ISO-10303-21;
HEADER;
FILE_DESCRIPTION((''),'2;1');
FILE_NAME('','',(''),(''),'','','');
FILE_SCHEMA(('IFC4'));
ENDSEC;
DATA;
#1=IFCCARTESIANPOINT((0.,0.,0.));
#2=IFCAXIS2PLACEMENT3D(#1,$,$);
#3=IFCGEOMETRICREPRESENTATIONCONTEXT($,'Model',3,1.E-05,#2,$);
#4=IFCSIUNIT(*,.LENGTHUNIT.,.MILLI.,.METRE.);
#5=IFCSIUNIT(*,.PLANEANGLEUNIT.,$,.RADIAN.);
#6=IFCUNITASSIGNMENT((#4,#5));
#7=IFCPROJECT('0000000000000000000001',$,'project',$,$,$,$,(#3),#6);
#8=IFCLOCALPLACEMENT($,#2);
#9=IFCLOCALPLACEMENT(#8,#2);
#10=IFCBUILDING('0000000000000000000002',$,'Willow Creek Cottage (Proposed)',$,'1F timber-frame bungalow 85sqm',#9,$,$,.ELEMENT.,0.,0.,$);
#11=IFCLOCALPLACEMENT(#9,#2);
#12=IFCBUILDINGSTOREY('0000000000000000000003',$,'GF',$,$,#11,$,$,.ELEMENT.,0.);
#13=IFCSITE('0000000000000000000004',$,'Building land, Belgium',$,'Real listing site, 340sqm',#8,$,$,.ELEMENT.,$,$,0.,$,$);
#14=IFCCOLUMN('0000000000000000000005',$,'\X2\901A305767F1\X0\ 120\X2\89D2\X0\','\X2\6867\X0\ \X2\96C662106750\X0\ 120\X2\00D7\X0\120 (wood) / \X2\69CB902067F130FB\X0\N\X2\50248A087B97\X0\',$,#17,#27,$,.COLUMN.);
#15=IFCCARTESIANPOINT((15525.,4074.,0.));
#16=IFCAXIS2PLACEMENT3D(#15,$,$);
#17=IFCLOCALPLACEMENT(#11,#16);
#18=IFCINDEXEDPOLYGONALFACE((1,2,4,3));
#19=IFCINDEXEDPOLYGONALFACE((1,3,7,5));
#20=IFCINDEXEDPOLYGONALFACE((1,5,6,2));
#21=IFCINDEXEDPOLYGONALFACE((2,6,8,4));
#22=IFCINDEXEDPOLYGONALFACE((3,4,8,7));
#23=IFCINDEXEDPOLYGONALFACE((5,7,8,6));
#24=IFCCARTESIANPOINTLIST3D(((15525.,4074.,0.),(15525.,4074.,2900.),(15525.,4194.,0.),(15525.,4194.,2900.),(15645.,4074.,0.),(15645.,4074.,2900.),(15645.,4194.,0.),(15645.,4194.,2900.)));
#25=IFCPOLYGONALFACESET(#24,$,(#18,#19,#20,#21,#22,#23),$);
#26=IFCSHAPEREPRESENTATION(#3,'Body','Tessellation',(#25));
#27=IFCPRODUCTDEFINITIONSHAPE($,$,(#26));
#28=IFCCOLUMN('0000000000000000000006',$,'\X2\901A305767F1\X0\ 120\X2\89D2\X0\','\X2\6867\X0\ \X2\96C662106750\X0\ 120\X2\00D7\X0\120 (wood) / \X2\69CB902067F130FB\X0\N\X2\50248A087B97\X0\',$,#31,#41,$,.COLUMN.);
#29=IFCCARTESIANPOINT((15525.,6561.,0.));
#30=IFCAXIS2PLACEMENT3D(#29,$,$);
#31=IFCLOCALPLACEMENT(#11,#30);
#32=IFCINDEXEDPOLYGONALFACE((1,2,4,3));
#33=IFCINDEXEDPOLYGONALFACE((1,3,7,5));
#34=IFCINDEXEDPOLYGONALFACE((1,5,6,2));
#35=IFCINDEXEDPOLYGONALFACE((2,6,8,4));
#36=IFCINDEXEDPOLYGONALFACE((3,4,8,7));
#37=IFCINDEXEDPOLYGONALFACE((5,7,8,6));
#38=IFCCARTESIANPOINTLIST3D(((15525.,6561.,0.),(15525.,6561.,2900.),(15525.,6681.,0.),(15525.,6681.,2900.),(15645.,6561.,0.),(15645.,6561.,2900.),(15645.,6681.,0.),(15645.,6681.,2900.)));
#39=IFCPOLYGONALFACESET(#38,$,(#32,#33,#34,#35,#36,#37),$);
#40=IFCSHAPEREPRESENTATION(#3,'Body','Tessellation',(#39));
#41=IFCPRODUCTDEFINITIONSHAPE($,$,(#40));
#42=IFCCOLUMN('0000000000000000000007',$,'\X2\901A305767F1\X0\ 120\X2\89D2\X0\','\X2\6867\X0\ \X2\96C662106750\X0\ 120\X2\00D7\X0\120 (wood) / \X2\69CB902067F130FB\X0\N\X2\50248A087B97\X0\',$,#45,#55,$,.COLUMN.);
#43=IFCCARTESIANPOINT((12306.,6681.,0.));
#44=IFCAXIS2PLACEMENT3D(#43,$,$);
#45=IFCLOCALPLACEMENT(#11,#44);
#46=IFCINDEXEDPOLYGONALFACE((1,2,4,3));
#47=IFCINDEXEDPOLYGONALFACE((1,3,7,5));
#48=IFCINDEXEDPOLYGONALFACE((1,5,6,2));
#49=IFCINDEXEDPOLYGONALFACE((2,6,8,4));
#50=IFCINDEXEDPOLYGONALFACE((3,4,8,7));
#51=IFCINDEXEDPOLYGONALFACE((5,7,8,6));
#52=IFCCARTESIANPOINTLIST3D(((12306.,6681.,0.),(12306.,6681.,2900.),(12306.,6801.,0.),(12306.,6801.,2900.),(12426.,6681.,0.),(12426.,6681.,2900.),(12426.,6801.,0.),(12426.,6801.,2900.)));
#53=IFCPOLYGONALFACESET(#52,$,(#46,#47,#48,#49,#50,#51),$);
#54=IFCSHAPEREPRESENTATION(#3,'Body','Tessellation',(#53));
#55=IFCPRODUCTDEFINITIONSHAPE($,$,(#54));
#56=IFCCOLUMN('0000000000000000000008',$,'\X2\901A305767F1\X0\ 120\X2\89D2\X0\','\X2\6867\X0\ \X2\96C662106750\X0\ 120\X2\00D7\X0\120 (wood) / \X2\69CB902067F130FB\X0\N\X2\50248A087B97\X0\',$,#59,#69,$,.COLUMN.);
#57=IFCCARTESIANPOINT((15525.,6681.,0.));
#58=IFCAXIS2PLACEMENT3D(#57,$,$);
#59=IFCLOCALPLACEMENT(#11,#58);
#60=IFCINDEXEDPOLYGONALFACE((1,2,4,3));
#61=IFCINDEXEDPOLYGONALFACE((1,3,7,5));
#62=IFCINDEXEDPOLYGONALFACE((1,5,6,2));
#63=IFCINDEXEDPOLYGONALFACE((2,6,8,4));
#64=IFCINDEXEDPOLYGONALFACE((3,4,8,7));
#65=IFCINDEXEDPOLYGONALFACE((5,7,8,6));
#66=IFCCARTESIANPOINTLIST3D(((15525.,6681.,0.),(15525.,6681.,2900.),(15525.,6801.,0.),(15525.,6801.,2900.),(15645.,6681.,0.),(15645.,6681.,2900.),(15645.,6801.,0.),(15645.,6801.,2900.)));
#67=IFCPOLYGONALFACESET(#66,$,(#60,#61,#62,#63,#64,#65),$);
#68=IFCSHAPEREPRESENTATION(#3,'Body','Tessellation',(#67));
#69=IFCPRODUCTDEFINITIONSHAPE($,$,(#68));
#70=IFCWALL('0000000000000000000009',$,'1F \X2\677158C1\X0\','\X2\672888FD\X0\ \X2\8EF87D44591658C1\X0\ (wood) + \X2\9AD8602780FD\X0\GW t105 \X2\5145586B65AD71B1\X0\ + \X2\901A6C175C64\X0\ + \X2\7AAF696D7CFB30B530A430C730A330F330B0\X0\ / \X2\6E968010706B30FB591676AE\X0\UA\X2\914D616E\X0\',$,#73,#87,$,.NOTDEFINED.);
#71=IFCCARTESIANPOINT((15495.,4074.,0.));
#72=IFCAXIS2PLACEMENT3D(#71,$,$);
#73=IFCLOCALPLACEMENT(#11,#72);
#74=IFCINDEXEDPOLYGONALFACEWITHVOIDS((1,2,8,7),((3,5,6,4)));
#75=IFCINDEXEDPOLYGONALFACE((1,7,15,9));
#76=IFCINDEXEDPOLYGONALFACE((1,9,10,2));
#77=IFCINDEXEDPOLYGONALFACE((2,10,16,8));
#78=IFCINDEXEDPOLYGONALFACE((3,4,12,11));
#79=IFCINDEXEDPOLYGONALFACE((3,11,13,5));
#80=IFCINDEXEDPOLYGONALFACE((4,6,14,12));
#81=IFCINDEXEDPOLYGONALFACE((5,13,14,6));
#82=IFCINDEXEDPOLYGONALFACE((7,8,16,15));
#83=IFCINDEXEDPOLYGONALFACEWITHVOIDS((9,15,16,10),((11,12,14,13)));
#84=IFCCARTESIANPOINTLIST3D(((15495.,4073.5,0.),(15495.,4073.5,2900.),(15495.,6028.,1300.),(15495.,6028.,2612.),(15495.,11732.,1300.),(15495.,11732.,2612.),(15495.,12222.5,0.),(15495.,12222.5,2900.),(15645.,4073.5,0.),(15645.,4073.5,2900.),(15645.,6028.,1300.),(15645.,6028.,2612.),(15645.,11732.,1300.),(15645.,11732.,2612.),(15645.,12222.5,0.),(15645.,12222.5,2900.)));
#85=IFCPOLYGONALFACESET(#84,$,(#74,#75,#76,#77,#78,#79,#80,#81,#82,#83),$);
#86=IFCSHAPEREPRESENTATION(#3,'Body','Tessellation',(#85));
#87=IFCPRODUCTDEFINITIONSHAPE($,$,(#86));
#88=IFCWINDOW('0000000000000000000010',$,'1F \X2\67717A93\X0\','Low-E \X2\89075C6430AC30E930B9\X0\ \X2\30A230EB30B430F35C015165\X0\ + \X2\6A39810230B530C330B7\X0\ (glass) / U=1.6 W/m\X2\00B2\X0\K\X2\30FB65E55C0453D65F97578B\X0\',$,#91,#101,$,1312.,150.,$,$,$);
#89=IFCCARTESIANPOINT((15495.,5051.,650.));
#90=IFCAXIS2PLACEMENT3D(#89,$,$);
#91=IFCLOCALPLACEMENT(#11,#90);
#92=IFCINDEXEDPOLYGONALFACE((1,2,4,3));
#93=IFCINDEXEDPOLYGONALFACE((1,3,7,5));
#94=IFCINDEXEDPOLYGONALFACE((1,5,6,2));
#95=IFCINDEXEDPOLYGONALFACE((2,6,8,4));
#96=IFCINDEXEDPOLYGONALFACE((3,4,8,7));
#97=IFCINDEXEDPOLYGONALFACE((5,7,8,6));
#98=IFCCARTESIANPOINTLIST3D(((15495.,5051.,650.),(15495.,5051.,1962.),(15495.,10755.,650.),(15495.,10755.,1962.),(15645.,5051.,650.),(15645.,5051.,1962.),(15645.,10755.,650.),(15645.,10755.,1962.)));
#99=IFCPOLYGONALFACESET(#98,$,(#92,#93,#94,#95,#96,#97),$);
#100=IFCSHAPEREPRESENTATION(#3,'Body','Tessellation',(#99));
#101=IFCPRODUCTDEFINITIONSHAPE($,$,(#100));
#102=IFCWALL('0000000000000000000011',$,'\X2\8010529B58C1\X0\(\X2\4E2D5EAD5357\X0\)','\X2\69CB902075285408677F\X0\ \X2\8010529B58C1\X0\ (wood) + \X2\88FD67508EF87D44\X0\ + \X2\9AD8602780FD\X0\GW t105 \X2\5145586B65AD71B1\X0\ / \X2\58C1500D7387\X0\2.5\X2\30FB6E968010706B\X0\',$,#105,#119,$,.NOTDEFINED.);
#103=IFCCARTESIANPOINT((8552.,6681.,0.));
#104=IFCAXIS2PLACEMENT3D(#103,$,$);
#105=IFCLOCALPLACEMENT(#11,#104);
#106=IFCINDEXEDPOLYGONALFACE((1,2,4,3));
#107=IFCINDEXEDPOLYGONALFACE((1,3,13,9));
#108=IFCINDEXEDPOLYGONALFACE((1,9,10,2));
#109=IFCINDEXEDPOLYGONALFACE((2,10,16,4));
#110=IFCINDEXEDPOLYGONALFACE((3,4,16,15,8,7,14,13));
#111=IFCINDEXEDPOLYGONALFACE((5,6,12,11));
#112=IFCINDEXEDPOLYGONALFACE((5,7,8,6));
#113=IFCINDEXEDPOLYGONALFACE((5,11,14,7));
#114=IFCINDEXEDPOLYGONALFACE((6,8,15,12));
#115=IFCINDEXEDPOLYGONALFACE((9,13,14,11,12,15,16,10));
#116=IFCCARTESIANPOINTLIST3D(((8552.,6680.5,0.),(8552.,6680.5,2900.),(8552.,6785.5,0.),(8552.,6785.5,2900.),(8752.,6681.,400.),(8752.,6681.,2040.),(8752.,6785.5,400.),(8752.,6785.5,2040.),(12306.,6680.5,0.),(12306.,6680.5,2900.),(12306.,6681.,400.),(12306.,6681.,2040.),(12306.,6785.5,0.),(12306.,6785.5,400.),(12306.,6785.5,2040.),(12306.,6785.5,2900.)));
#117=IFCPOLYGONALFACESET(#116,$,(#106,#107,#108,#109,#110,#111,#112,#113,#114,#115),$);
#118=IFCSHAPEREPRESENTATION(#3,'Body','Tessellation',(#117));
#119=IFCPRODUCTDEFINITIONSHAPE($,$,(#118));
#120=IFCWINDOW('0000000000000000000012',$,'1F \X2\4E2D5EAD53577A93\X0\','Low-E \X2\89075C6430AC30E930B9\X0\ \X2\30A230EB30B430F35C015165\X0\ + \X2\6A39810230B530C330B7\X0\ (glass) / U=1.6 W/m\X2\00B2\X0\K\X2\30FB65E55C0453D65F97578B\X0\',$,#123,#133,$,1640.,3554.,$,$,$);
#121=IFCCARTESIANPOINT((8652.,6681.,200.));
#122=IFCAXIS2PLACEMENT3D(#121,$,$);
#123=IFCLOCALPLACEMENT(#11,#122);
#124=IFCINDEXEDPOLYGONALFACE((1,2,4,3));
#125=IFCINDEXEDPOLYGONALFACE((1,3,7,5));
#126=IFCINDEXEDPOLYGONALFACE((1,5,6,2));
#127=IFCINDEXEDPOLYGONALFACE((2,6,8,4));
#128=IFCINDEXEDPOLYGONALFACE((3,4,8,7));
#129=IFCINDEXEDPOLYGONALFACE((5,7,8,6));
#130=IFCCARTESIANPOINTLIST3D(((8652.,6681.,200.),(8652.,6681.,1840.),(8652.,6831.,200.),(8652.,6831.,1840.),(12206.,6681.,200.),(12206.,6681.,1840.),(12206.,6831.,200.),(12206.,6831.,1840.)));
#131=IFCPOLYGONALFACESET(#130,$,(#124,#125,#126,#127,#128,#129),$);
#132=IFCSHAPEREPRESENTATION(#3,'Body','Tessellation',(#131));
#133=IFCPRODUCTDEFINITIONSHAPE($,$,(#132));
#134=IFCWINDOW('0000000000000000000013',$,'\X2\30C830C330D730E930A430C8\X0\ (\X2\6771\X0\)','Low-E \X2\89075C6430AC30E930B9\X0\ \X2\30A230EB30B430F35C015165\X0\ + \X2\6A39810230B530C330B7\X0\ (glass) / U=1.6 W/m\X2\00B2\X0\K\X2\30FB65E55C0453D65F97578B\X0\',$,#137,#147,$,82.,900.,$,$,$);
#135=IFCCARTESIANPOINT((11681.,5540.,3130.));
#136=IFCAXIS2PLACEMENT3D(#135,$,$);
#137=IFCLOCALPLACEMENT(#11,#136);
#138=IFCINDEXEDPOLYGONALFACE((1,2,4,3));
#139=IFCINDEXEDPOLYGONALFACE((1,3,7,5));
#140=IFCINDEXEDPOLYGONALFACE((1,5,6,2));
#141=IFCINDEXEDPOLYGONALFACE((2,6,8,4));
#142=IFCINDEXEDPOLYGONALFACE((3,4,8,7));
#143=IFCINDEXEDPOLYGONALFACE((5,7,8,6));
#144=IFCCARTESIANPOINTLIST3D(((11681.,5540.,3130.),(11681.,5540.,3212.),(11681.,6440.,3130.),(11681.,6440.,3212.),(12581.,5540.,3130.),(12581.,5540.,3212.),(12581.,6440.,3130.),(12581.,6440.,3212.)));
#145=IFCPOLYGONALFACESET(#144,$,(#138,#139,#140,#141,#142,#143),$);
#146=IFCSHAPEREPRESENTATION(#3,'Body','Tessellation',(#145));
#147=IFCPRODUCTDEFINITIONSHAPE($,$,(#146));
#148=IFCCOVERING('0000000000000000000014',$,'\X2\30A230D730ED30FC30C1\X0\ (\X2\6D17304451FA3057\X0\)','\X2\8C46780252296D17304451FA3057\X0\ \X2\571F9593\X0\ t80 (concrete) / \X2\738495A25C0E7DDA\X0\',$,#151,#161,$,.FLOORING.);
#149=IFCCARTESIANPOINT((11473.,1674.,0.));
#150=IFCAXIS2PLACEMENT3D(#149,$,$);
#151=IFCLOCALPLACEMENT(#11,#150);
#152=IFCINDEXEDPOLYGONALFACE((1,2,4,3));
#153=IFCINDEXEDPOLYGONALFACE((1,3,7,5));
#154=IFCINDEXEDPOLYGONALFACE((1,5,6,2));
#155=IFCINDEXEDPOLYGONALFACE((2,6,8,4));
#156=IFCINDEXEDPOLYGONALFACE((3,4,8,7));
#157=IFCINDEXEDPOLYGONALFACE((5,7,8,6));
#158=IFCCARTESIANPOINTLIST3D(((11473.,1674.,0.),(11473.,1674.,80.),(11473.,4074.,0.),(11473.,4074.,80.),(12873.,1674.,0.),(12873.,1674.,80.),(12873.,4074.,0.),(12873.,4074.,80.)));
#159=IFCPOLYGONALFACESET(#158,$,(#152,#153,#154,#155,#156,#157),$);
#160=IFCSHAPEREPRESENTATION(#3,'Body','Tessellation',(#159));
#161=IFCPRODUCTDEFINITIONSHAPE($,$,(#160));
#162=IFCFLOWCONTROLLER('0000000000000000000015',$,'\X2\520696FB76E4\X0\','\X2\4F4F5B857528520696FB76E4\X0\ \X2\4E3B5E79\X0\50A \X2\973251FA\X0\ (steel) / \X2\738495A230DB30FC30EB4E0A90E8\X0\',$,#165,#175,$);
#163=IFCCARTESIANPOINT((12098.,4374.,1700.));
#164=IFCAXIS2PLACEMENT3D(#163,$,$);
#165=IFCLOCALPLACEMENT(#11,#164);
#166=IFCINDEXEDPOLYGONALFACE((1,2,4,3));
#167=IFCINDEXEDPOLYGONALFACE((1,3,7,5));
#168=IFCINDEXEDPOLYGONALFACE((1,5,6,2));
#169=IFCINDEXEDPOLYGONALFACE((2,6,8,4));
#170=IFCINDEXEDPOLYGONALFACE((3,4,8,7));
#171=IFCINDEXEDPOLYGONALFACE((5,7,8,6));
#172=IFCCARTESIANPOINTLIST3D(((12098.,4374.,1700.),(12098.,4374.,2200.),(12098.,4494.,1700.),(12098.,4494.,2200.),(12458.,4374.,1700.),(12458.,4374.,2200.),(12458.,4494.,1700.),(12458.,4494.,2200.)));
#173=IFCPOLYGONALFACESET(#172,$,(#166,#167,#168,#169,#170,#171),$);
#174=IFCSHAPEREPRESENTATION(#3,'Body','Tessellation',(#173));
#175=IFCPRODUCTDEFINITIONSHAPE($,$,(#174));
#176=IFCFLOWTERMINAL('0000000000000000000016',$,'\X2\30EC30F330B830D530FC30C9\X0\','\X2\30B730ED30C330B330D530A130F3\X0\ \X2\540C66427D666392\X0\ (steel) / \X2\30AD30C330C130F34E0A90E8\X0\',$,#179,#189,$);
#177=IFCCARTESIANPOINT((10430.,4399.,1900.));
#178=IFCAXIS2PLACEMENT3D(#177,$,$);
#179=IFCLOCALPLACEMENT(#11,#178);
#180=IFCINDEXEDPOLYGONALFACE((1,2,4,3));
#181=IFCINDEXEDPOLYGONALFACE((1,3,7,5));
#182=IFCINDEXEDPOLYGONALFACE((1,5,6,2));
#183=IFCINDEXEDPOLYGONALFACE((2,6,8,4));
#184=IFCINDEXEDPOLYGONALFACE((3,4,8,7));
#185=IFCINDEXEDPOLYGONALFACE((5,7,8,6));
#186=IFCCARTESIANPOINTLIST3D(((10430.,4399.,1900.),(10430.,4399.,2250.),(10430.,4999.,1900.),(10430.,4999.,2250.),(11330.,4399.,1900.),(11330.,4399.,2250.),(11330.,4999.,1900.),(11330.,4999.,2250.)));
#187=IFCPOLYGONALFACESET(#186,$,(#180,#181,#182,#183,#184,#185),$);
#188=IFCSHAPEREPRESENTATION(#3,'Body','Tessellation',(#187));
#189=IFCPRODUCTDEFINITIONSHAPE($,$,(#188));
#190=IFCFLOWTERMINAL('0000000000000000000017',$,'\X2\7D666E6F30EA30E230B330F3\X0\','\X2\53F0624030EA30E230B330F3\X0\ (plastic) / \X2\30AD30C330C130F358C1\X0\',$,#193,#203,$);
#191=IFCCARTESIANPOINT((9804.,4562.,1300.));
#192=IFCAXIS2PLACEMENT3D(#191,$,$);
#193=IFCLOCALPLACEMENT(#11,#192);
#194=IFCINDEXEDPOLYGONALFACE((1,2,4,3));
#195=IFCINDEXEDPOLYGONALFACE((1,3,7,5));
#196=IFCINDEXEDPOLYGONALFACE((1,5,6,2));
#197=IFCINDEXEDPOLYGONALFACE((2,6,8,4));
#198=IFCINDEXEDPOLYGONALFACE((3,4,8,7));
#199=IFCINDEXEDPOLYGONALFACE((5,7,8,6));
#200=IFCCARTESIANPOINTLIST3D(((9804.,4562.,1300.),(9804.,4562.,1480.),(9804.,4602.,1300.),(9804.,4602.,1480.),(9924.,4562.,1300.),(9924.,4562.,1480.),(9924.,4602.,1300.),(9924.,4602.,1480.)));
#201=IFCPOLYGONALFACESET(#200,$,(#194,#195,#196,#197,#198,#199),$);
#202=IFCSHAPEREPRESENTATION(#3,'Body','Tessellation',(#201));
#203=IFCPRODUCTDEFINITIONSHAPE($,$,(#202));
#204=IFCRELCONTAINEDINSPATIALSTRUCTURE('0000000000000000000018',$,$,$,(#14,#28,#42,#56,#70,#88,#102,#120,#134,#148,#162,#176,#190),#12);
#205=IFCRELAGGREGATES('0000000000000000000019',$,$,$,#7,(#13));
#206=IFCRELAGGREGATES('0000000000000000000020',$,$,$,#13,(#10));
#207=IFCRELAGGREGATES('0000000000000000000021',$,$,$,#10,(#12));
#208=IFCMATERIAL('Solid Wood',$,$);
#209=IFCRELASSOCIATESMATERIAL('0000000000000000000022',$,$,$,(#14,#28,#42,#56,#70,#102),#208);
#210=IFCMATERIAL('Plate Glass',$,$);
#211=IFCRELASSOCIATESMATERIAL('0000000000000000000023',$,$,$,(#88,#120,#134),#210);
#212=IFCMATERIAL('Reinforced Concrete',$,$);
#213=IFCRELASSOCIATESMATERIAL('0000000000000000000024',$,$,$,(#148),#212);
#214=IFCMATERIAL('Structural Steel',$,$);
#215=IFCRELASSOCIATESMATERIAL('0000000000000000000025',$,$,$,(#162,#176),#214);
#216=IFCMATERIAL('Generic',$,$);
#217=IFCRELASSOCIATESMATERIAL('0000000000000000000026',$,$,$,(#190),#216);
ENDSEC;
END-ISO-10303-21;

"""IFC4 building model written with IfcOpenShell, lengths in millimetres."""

from ifc_helpers import new_model, si_unit, frame, frame_2d, origin, place, context, project, spatial, rectangle, extrude, material, element, fill, save


model = new_model("IFC4")

# Units and contexts
model_context = context("Model", 3, precision=1e-05, world=origin())
ifc_project = project(units=[si_unit("LENGTHUNIT", "METRE", prefix="MILLI"), si_unit("PLANEANGLEUNIT", "RADIAN")], contexts=[model_context])

# Site, building, storey
site_placement = place(None, origin())
site = spatial("IfcSite", under=ifc_project, at=site_placement, Name="Building land, Belgium", ObjectType="Real listing site, 340sqm", CompositionType="ELEMENT", RefElevation=0.0)
building_placement = place(site_placement, origin())
building = spatial("IfcBuilding", under=site, at=building_placement, Name="Willow Creek Cottage (Proposed)", ObjectType="1F timber-frame bungalow 85sqm", CompositionType="ELEMENT", ElevationOfRefHeight=0.0, ElevationOfTerrain=0.0)
storey_placement = place(building_placement, origin())
storey = spatial("IfcBuildingStorey", under=building, at=storey_placement, Name="GF", CompositionType="ELEMENT", Elevation=0.0)

# Columns
ifc_material_1 = material(Name="Solid Wood")
column_1_placement = place(storey_placement, frame((15525.0, 4074.0, 0.0)))
element("IfcColumn", 1, at=column_1_placement, inside=storey, material=ifc_material_1, Name="通し柱 120角", Description="桧 集成材 120×120 (wood) / 構造柱・N値計算", PredefinedType="COLUMN", context=model_context, shape_type="SweptSolid", body=[
    extrude(rectangle(XDim=120.0, YDim=120.0, at=frame_2d((60.0, 60.0))), frame((15525.0, 4074.0, 0.0)), (0.0, 0.0, 1.0), 2900.0),
])
column_2_placement = place(storey_placement, frame((15525.0, 6561.0, 0.0)))
element("IfcColumn", 2, at=column_2_placement, inside=storey, material=ifc_material_1, Name="通し柱 120角", Description="桧 集成材 120×120 (wood) / 構造柱・N値計算", PredefinedType="COLUMN", context=model_context, shape_type="SweptSolid", body=[
    extrude(rectangle(XDim=120.0, YDim=120.0, at=frame_2d((60.0, 60.0))), frame((15525.0, 6561.0, 0.0)), (0.0, 0.0, 1.0), 2900.0),
])
column_3_placement = place(storey_placement, frame((12306.0, 6681.0, 0.0)))
element("IfcColumn", 3, at=column_3_placement, inside=storey, material=ifc_material_1, Name="通し柱 120角", Description="桧 集成材 120×120 (wood) / 構造柱・N値計算", PredefinedType="COLUMN", context=model_context, shape_type="SweptSolid", body=[
    extrude(rectangle(XDim=120.0, YDim=120.0, at=frame_2d((60.0, 60.0))), frame((12306.0, 6681.0, 0.0)), (0.0, 0.0, 1.0), 2900.0),
])
column_4_placement = place(storey_placement, frame((15525.0, 6681.0, 0.0)))
element("IfcColumn", 4, at=column_4_placement, inside=storey, material=ifc_material_1, Name="通し柱 120角", Description="桧 集成材 120×120 (wood) / 構造柱・N値計算", PredefinedType="COLUMN", context=model_context, shape_type="SweptSolid", body=[
    extrude(rectangle(XDim=120.0, YDim=120.0, at=frame_2d((60.0, 60.0))), frame((15525.0, 6681.0, 0.0)), (0.0, 0.0, 1.0), 2900.0),
])

# Walls, openings, windows
wall_1_placement = place(storey_placement, frame((15495.0, 4074.0, 0.0)))
wall_1 = element("IfcWall", 5, at=wall_1_placement, inside=storey, material=ifc_material_1, Name="1F 東壁", Description="木製 軸組外壁 (wood) + 高性能GW t105 充填断熱 + 通気層 + 窯業系サイディング / 準耐火・外皮UA配慮", PredefinedType="NOTDEFINED", context=model_context, shape_type="SweptSolid", body=[
    extrude(rectangle(XDim=150.0, YDim=8149.0, at=frame_2d((75.0, 4074.0))), frame((15495.0, 4074.0, 0.0)), (0.0, 0.0, 1.0), 2900.0),
])
opening_1_placement = place(storey_placement, frame((15495.0, 5051.0, 650.0)))
opening_1 = element("IfcOpeningElement", 6, at=opening_1_placement, cuts=wall_1, PredefinedType="NOTDEFINED", context=model_context, shape_type="SweptSolid", body=[
    extrude(rectangle(XDim=150.0, YDim=5704.0, at=frame_2d((75.0, 2852.0))), frame((15495.0, 5051.0, 650.0)), (0.0, 0.0, 1.0), 1312.0),
])
ifc_material_2 = material(Name="Plate Glass")
window_1_placement = place(storey_placement, frame((15495.0, 5051.0, 650.0)))
window_1 = element("IfcWindow", 7, at=window_1_placement, inside=storey, material=ifc_material_2, Name="1F 東窓", Description="Low-E 複層ガラス アルゴン封入 + 樹脂サッシ (glass) / U=1.6 W/m²K・日射取得型", OverallHeight=1312.0, OverallWidth=150.0, context=model_context, shape_type="SweptSolid", body=[
    extrude(rectangle(XDim=150.0, YDim=5704.0, at=frame_2d((75.0, 2852.0))), frame((15495.0, 5051.0, 650.0)), (0.0, 0.0, 1.0), 1312.0),
])
fill(opening_1, window_1)
wall_2_placement = place(storey_placement, frame((8552.0, 6681.0, 0.0)))
wall_2 = element("IfcWall", 8, at=wall_2_placement, inside=storey, material=ifc_material_1, Name="耐力壁(中庭南)", Description="構造用合板 耐力壁 (wood) + 製材軸組 + 高性能GW t105 充填断熱 / 壁倍率2.5・準耐火", PredefinedType="NOTDEFINED", context=model_context, shape_type="SweptSolid", body=[
    extrude(rectangle(XDim=3754.0, YDim=105.0, at=frame_2d((1877.0, 52.0))), frame((8552.0, 6681.0, 0.0)), (0.0, 0.0, 1.0), 2900.0),
])
opening_2_placement = place(storey_placement, frame((8652.0, 6681.0, 200.0)))
opening_2 = element("IfcOpeningElement", 9, at=opening_2_placement, cuts=wall_2, PredefinedType="NOTDEFINED", context=model_context, shape_type="SweptSolid", body=[
    extrude(rectangle(XDim=3554.0, YDim=150.0, at=frame_2d((1777.0, 75.0))), frame((8652.0, 6681.0, 200.0)), (0.0, 0.0, 1.0), 1640.0),
])
window_2_placement = place(storey_placement, frame((8652.0, 6681.0, 200.0)))
window_2 = element("IfcWindow", 10, at=window_2_placement, inside=storey, material=ifc_material_2, Name="1F 中庭南窓", Description="Low-E 複層ガラス アルゴン封入 + 樹脂サッシ (glass) / U=1.6 W/m²K・日射取得型", OverallHeight=1640.0, OverallWidth=3554.0, context=model_context, shape_type="SweptSolid", body=[
    extrude(rectangle(XDim=3554.0, YDim=150.0, at=frame_2d((1777.0, 75.0))), frame((8652.0, 6681.0, 200.0)), (0.0, 0.0, 1.0), 1640.0),
])
fill(opening_2, window_2)

# Window
window_3_placement = place(storey_placement, frame((11681.0, 5540.0, 3130.0)))
element("IfcWindow", 11, at=window_3_placement, inside=storey, material=ifc_material_2, Name="トップライト (東)", Description="Low-E 複層ガラス アルゴン封入 + 樹脂サッシ (glass) / U=1.6 W/m²K・日射取得型", OverallHeight=82.0, OverallWidth=900.0, context=model_context, shape_type="SweptSolid", body=[
    extrude(rectangle(XDim=900.0, YDim=900.0, at=frame_2d((450.0, 450.0))), frame((11681.0, 5540.0, 3130.0)), (0.0, 0.0, 1.0), 82.0),
])

# Shared definitions
ifc_material_3 = material(Name="Structural Steel")

# Covering
ifc_material_4 = material(Name="Reinforced Concrete")
covering_placement = place(storey_placement, frame((11473.0, 1674.0, 0.0)))
element("IfcCovering", 12, at=covering_placement, inside=storey, material=ifc_material_4, Name="アプローチ (洗い出し)", Description="豆砂利洗い出し 土間 t80 (concrete) / 玄関導線", PredefinedType="FLOORING", context=model_context, shape_type="SweptSolid", body=[
    extrude(rectangle(XDim=1400.0, YDim=2400.0, at=frame_2d((700.0, 1200.0))), frame((11473.0, 1674.0, 0.0)), (0.0, 0.0, 1.0), 80.0),
])

# Flow controller
flow_controller_placement = place(storey_placement, frame((12098.0, 4374.0, 1700.0)))
element("IfcFlowController", 13, at=flow_controller_placement, inside=storey, material=ifc_material_3, Name="分電盤", Description="住宅用分電盤 主幹50A 露出 (steel) / 玄関ホール上部", context=model_context, shape_type="SweptSolid", body=[
    extrude(rectangle(XDim=360.0, YDim=120.0, at=frame_2d((180.0, 60.0))), frame((12098.0, 4374.0, 1700.0)), (0.0, 0.0, 1.0), 500.0),
])

# Flow terminals
flow_terminal_1_placement = place(storey_placement, frame((10430.0, 4399.0, 1900.0)))
element("IfcFlowTerminal", 14, at=flow_terminal_1_placement, inside=storey, material=ifc_material_3, Name="レンジフード", Description="シロッコファン 同時給排 (steel) / キッチン上部", context=model_context, shape_type="SweptSolid", body=[
    extrude(rectangle(XDim=900.0, YDim=600.0, at=frame_2d((450.0, 300.0))), frame((10430.0, 4399.0, 1900.0)), (0.0, 0.0, 1.0), 350.0),
])
ifc_material_5 = material(Name="Generic")
flow_terminal_2_placement = place(storey_placement, frame((9804.0, 4562.0, 1300.0)))
element("IfcFlowTerminal", 15, at=flow_terminal_2_placement, inside=storey, material=ifc_material_5, Name="給湯リモコン", Description="台所リモコン (plastic) / キッチン壁", context=model_context, shape_type="SweptSolid", body=[
    extrude(rectangle(XDim=120.0, YDim=40.0, at=frame_2d((60.0, 20.0))), frame((9804.0, 4562.0, 1300.0)), (0.0, 0.0, 1.0), 180.0),
])

save(model, "model.ifc")
